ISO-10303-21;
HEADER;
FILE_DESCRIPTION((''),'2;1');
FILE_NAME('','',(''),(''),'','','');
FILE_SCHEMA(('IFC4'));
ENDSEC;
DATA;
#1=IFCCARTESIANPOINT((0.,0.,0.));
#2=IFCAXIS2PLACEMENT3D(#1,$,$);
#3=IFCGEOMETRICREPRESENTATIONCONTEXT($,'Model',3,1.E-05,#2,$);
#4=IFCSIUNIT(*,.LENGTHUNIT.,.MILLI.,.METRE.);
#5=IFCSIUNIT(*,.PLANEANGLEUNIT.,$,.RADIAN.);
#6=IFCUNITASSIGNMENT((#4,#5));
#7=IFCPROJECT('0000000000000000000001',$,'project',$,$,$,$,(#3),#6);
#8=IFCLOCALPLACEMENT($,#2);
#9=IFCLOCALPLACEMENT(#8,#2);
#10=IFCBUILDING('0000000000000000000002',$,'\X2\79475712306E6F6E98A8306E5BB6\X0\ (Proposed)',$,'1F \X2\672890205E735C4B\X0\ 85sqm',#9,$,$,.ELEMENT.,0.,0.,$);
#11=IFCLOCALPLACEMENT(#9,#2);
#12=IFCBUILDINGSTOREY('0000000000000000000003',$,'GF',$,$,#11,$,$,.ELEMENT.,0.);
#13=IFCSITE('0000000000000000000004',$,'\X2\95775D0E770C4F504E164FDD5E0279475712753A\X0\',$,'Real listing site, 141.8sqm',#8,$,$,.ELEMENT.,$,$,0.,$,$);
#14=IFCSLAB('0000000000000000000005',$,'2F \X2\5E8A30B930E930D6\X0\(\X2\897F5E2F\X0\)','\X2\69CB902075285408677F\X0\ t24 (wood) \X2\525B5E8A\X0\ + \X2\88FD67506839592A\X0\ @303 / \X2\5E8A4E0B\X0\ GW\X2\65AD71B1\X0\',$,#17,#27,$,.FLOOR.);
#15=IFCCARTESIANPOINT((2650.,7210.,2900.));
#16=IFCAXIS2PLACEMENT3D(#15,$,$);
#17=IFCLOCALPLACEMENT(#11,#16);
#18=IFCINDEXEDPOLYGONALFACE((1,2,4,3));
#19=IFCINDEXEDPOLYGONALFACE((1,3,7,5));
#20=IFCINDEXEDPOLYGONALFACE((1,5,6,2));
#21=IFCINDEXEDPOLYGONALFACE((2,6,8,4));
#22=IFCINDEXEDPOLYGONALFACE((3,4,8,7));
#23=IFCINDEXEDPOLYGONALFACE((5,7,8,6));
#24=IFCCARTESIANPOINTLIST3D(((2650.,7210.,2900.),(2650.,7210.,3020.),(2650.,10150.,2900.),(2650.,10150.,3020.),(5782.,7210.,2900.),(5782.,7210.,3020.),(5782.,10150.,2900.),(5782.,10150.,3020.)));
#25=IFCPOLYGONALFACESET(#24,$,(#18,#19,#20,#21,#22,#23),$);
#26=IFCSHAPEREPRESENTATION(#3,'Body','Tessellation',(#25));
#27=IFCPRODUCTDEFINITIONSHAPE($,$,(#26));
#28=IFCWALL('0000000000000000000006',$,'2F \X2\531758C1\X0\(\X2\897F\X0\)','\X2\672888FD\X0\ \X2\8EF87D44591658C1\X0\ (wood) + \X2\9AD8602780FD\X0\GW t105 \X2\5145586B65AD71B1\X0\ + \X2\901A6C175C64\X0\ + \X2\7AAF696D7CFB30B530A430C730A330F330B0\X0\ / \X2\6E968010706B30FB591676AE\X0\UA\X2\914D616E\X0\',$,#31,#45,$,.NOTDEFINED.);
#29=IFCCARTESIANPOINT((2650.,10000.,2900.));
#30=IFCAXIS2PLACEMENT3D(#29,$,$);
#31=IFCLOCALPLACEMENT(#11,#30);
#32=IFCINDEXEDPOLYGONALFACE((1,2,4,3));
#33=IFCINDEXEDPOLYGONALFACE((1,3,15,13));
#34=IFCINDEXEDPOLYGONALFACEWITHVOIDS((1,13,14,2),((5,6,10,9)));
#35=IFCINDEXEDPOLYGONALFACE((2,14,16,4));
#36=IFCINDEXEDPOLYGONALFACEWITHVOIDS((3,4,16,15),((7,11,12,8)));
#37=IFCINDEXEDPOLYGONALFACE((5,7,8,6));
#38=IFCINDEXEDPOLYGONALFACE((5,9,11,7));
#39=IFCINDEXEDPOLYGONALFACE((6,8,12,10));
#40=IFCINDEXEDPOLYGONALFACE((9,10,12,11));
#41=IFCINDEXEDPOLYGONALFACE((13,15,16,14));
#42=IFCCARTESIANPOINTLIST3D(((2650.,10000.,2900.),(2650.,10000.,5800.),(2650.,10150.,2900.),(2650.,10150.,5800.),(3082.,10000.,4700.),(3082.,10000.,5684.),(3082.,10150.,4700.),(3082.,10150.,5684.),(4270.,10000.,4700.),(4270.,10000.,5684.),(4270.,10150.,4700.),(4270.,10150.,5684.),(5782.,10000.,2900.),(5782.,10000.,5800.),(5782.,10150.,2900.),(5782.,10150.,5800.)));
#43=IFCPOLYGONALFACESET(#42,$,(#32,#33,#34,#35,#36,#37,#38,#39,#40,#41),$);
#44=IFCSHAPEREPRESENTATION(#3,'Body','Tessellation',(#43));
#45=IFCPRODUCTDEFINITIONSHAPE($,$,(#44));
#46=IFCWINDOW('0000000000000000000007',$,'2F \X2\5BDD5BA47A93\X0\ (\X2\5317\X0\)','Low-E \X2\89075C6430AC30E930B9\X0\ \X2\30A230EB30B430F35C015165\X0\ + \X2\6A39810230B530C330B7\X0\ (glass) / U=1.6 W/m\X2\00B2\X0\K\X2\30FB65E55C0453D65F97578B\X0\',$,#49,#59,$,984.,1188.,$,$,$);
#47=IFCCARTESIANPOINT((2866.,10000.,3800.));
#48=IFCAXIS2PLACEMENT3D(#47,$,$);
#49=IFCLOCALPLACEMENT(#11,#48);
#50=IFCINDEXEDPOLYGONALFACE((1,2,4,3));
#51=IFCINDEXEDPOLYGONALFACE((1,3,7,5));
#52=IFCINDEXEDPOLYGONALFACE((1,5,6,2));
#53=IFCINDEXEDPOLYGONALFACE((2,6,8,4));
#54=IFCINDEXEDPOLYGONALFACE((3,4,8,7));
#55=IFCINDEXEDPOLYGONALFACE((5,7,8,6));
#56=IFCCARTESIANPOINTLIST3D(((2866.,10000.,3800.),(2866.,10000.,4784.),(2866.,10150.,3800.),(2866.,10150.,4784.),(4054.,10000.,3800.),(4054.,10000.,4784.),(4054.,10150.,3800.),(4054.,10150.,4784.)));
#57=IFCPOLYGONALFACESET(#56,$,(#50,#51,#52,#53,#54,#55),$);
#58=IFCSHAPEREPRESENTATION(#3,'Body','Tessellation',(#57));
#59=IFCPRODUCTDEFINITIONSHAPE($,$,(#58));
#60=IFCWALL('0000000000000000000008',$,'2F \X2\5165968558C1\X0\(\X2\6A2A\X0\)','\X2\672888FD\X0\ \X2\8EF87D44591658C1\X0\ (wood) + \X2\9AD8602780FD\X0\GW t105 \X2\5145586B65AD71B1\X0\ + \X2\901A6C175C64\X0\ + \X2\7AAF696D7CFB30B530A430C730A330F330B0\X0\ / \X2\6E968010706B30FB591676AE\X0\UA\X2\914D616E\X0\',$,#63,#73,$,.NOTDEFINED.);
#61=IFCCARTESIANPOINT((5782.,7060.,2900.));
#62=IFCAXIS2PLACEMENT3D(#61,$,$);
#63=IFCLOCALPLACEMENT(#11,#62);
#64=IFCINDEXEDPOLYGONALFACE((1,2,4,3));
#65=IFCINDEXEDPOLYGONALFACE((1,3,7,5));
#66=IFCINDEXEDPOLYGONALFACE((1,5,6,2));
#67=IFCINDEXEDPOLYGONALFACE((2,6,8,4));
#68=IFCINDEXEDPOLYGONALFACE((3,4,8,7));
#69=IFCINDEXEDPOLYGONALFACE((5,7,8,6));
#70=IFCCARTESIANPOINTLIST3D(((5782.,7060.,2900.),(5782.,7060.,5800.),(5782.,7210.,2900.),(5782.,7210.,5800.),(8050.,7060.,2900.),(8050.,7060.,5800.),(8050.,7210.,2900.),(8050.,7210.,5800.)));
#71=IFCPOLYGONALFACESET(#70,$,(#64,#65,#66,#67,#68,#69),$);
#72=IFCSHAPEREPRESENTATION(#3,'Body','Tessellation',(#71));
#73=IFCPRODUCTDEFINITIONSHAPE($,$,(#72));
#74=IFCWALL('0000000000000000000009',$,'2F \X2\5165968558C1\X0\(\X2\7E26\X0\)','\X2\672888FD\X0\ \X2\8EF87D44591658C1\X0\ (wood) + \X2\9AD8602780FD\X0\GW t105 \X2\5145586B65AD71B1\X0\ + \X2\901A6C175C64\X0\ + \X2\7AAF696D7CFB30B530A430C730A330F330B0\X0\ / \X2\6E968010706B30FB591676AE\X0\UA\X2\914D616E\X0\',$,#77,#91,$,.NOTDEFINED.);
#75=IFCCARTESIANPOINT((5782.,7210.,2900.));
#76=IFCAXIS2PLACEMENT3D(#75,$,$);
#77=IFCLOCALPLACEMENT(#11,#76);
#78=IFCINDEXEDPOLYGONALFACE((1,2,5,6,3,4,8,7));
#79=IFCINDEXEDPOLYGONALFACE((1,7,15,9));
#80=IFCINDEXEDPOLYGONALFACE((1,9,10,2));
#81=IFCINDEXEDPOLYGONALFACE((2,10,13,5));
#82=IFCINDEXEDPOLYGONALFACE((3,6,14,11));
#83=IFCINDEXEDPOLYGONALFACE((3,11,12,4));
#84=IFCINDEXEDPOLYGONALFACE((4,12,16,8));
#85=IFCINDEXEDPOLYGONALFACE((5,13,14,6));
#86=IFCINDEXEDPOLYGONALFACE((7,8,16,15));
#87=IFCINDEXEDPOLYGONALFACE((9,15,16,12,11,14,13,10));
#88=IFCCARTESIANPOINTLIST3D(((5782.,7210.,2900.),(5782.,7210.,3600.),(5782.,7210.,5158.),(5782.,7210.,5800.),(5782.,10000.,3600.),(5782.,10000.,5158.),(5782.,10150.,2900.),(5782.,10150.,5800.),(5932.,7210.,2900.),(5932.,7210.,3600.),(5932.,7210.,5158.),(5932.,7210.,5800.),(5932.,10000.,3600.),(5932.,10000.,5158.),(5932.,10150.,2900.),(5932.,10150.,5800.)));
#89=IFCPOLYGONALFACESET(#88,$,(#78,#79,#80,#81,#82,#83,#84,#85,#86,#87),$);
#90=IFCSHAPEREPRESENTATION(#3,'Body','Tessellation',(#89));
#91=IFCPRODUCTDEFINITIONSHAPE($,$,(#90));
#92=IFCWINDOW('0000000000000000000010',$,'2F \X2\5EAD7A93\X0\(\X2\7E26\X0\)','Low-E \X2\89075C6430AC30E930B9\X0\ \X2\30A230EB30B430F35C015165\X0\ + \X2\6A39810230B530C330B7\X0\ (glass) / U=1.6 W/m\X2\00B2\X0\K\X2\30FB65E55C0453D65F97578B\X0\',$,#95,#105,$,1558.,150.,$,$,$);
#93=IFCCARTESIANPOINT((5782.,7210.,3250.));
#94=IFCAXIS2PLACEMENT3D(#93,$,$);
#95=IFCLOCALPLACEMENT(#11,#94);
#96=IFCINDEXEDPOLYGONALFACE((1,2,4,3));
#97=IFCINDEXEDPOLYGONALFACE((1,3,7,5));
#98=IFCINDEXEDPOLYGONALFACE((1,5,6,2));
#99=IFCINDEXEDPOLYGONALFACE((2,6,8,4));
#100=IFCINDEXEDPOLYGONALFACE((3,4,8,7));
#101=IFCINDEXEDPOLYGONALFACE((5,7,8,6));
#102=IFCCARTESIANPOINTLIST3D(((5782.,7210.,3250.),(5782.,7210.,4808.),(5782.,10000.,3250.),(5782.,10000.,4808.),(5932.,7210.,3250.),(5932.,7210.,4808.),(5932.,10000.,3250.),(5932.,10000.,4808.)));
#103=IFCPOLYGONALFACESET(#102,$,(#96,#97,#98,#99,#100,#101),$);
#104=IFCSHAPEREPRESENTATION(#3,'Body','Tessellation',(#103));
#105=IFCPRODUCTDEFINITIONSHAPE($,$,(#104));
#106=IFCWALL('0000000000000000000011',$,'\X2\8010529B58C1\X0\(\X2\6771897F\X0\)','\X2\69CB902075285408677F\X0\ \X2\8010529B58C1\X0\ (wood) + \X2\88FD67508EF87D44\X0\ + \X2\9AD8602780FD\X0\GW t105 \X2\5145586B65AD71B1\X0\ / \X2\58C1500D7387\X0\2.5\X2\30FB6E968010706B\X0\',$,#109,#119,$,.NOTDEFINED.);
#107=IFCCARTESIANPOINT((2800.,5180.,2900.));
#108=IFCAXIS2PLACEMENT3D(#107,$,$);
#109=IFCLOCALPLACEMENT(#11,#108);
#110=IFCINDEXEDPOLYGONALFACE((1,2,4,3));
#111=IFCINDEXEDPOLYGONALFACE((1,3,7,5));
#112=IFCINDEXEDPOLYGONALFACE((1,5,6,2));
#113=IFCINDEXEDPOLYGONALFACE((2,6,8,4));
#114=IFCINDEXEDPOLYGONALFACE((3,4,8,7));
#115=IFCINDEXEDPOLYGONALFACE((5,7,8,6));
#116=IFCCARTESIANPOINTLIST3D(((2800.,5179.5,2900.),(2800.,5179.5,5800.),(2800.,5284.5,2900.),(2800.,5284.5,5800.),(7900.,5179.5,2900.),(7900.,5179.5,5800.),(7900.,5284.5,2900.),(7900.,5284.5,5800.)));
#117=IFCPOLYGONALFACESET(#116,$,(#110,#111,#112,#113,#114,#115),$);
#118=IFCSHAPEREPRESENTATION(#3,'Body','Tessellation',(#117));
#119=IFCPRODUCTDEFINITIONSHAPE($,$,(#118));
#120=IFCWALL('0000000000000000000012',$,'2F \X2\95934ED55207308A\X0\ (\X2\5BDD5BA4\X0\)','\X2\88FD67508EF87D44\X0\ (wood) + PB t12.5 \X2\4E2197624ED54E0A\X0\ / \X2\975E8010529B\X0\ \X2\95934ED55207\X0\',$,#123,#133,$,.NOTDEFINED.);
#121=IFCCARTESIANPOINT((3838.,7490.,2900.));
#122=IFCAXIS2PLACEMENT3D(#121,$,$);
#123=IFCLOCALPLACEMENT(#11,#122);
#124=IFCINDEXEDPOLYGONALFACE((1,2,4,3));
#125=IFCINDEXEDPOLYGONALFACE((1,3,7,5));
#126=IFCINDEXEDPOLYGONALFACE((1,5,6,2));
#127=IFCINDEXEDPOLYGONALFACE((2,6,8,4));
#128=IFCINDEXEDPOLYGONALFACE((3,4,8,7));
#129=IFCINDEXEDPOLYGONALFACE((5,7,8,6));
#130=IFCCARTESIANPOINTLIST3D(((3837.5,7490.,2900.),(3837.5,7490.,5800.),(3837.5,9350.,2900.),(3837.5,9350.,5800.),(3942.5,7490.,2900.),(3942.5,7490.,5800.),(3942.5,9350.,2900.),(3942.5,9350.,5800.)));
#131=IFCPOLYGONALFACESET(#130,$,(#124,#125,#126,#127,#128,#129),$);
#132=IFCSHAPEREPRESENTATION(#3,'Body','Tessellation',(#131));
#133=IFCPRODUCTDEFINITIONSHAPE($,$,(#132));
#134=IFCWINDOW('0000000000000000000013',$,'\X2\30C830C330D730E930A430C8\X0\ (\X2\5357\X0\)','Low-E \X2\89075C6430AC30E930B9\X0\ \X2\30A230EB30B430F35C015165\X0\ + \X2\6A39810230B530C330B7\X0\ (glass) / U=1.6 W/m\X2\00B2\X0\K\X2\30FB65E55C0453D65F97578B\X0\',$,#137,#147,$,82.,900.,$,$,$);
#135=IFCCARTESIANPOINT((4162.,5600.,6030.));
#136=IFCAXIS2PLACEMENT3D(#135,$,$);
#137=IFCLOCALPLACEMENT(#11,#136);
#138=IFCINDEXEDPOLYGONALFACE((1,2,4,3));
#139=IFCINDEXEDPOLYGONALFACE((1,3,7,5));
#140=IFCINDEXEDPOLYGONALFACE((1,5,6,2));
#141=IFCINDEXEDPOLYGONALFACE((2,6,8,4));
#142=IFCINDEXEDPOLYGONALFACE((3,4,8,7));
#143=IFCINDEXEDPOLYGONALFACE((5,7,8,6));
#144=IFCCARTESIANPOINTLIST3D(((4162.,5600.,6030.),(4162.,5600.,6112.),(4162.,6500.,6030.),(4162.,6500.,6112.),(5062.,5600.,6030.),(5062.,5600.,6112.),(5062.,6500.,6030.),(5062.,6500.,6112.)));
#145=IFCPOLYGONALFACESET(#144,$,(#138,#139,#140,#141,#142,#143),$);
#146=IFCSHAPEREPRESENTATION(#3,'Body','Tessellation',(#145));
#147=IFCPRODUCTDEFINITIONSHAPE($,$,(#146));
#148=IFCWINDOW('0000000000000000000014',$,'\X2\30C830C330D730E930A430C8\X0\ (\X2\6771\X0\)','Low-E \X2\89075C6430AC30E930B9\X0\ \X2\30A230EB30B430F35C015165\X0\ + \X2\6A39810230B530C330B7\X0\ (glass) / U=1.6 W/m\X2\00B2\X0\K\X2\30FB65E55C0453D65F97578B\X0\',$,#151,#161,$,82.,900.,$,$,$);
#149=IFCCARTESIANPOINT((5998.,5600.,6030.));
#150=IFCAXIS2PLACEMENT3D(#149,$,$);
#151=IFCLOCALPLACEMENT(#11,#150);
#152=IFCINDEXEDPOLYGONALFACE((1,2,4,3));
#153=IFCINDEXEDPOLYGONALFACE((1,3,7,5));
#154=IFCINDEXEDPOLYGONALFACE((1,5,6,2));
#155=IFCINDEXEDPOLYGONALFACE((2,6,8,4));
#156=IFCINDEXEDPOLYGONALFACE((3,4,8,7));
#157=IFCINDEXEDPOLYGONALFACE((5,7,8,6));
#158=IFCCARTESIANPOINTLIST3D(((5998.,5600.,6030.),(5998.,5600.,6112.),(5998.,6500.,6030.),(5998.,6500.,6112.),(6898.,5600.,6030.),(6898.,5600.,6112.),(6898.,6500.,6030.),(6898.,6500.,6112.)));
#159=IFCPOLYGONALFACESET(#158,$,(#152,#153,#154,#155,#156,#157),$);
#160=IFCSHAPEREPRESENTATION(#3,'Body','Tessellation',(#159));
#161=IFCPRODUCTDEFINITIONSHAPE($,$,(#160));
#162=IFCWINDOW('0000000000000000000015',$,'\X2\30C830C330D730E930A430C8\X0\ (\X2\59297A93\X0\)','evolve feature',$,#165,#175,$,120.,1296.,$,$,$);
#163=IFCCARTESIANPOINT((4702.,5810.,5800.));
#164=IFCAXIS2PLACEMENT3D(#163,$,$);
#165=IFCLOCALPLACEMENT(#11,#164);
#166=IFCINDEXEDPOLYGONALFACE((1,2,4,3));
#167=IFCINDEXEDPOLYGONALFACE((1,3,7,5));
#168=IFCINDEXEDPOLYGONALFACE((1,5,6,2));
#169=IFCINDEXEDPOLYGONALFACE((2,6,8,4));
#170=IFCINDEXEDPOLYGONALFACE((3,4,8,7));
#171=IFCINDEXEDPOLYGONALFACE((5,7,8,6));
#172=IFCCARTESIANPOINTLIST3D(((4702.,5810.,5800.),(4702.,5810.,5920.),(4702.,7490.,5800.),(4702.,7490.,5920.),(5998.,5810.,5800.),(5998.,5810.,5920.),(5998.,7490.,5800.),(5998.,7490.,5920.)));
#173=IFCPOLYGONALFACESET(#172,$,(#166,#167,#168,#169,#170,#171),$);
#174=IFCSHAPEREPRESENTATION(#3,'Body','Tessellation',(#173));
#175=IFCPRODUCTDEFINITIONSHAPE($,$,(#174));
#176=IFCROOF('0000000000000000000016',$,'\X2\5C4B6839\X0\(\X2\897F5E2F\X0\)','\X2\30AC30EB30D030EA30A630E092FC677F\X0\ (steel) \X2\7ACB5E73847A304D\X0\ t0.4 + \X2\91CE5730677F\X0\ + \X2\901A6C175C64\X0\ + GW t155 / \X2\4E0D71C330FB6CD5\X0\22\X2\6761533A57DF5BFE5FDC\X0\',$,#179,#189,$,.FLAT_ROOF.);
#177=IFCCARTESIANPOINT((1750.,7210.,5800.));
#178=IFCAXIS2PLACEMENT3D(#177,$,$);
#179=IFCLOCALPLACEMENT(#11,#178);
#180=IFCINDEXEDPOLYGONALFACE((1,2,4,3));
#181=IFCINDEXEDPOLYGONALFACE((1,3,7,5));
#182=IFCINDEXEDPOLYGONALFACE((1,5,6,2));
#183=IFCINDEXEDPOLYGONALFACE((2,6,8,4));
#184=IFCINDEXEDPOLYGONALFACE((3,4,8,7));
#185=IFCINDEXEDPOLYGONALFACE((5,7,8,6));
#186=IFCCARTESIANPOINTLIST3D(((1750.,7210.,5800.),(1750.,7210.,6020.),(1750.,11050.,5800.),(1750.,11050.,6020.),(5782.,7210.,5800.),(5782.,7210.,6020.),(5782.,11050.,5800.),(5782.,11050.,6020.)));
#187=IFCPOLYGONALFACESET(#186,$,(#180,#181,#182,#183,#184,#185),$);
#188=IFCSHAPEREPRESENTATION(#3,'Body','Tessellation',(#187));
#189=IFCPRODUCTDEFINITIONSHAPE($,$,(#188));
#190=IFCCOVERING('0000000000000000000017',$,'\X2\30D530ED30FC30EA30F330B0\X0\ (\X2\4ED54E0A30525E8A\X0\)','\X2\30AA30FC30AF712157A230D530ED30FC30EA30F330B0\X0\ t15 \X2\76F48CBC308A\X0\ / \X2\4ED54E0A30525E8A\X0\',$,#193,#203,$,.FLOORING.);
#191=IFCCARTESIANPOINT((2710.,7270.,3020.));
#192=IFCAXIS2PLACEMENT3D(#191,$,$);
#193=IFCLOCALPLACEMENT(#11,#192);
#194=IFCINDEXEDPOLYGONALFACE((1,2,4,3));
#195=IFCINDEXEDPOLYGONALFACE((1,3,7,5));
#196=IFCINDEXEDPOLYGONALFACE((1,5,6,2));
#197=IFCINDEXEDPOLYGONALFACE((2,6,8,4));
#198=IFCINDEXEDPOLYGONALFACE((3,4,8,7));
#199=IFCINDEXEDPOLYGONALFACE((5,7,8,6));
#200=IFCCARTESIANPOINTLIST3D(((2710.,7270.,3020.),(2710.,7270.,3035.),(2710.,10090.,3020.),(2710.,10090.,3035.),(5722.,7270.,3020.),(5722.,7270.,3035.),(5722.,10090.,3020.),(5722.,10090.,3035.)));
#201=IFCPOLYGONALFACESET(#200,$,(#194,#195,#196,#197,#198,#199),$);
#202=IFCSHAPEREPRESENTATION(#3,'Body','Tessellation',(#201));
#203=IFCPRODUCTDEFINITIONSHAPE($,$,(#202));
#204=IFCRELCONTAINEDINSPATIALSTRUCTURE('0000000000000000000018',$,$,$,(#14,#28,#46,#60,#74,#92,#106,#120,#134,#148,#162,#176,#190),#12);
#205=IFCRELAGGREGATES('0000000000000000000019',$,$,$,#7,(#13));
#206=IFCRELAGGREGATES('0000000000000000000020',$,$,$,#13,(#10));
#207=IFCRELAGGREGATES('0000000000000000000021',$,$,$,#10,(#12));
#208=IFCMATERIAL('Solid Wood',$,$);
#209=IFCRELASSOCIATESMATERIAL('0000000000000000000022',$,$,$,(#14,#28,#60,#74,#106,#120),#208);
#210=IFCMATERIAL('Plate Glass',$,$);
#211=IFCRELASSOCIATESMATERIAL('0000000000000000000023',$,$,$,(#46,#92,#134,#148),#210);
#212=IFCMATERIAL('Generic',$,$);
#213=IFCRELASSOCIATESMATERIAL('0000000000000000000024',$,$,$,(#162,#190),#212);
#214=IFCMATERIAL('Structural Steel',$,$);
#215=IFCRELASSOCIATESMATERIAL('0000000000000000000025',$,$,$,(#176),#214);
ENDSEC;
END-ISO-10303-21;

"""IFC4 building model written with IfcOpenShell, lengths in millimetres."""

from ifc_helpers import new_model, si_unit, frame, frame_2d, origin, place, context, project, spatial, rectangle, extrude, material, element, fill, save


model = new_model("IFC4")

# Units and contexts
model_context = context("Model", 3, precision=1e-05, world=origin())
ifc_project = project(units=[si_unit("LENGTHUNIT", "METRE", prefix="MILLI"), si_unit("PLANEANGLEUNIT", "RADIAN")], contexts=[model_context])

# Site, building, storey
site_placement = place(None, origin())
site = spatial("IfcSite", under=ifc_project, at=site_placement, Name="長崎県佐世保市祇園町", ObjectType="Real listing site, 141.8sqm", CompositionType="ELEMENT", RefElevation=0.0)
building_placement = place(site_placement, origin())
building = spatial("IfcBuilding", under=site, at=building_placement, Name="祇園の潮風の家 (Proposed)", ObjectType="1F 木造平屋 85sqm", CompositionType="ELEMENT", ElevationOfRefHeight=0.0, ElevationOfTerrain=0.0)
storey_placement = place(building_placement, origin())
storey = spatial("IfcBuildingStorey", under=building, at=storey_placement, Name="GF", CompositionType="ELEMENT", Elevation=0.0)

# Slab
ifc_material_1 = material(Name="Solid Wood")
slab_placement = place(storey_placement, frame((2650.0, 7210.0, 2900.0)))
element("IfcSlab", 1, at=slab_placement, inside=storey, material=ifc_material_1, Name="2F 床スラブ(西帯)", Description="構造用合板 t24 (wood) 剛床 + 製材根太 @303 / 床下 GW断熱", PredefinedType="FLOOR", context=model_context, shape_type="SweptSolid", body=[
    extrude(rectangle(XDim=3132.0, YDim=2940.0, at=frame_2d((1566.0, 1470.0))), frame((2650.0, 7210.0, 2900.0)), (0.0, 0.0, 1.0), 120.0),
])

# Wall, opening, window
wall_1_placement = place(storey_placement, frame((2650.0, 10000.0, 2900.0)))
wall_1 = element("IfcWall", 2, at=wall_1_placement, inside=storey, material=ifc_material_1, Name="2F 北壁(西)", Description="木製 軸組外壁 (wood) + 高性能GW t105 充填断熱 + 通気層 + 窯業系サイディング / 準耐火・外皮UA配慮", PredefinedType="NOTDEFINED", context=model_context, shape_type="SweptSolid", body=[
    extrude(rectangle(XDim=3132.0, YDim=150.0, at=frame_2d((1566.0, 75.0))), frame((2650.0, 10000.0, 2900.0)), (0.0, 0.0, 1.0), 2900.0),
])
opening_1_placement = place(storey_placement, frame((2866.0, 10000.0, 3800.0)))
opening_1 = element("IfcOpeningElement", 3, at=opening_1_placement, cuts=wall_1, PredefinedType="NOTDEFINED", context=model_context, shape_type="SweptSolid", body=[
    extrude(rectangle(XDim=1188.0, YDim=150.0, at=frame_2d((594.0, 75.0))), frame((2866.0, 10000.0, 3800.0)), (0.0, 0.0, 1.0), 984.0),
])
ifc_material_2 = material(Name="Plate Glass")
window_1_placement = place(storey_placement, frame((2866.0, 10000.0, 3800.0)))
window_1 = element("IfcWindow", 4, at=window_1_placement, inside=storey, material=ifc_material_2, Name="2F 寝室窓 (北)", Description="Low-E 複層ガラス アルゴン封入 + 樹脂サッシ (glass) / U=1.6 W/m²K・日射取得型", OverallHeight=984.0, OverallWidth=1188.0, context=model_context, shape_type="SweptSolid", body=[
    extrude(rectangle(XDim=1188.0, YDim=150.0, at=frame_2d((594.0, 75.0))), frame((2866.0, 10000.0, 3800.0)), (0.0, 0.0, 1.0), 984.0),
])
fill(opening_1, window_1)

# Wall
wall_2_placement = place(storey_placement, frame((5782.0, 7060.0, 2900.0)))
element("IfcWall", 5, at=wall_2_placement, inside=storey, material=ifc_material_1, Name="2F 入隅壁(横)", Description="木製 軸組外壁 (wood) + 高性能GW t105 充填断熱 + 通気層 + 窯業系サイディング / 準耐火・外皮UA配慮", PredefinedType="NOTDEFINED", context=model_context, shape_type="SweptSolid", body=[
    extrude(rectangle(XDim=2268.0, YDim=150.0, at=frame_2d((1134.0, 75.0))), frame((5782.0, 7060.0, 2900.0)), (0.0, 0.0, 1.0), 2900.0),
])

# Wall, opening, window
wall_3_placement = place(storey_placement, frame((5782.0, 7210.0, 2900.0)))
wall_3 = element("IfcWall", 6, at=wall_3_placement, inside=storey, material=ifc_material_1, Name="2F 入隅壁(縦)", Description="木製 軸組外壁 (wood) + 高性能GW t105 充填断熱 + 通気層 + 窯業系サイディング / 準耐火・外皮UA配慮", PredefinedType="NOTDEFINED", context=model_context, shape_type="SweptSolid", body=[
    extrude(rectangle(XDim=150.0, YDim=2940.0, at=frame_2d((75.0, 1470.0))), frame((5782.0, 7210.0, 2900.0)), (0.0, 0.0, 1.0), 2900.0),
])
opening_2_placement = place(storey_placement, frame((5782.0, 7210.0, 3250.0)))
opening_2 = element("IfcOpeningElement", 7, at=opening_2_placement, cuts=wall_3, PredefinedType="NOTDEFINED", context=model_context, shape_type="SweptSolid", body=[
    extrude(rectangle(XDim=150.0, YDim=2790.0, at=frame_2d((75.0, 1395.0))), frame((5782.0, 7210.0, 3250.0)), (0.0, 0.0, 1.0), 1558.0),
])
window_2_placement = place(storey_placement, frame((5782.0, 7210.0, 3250.0)))
window_2 = element("IfcWindow", 8, at=window_2_placement, inside=storey, material=ifc_material_2, Name="2F 庭窓(縦)", Description="Low-E 複層ガラス アルゴン封入 + 樹脂サッシ (glass) / U=1.6 W/m²K・日射取得型", OverallHeight=1558.0, OverallWidth=150.0, context=model_context, shape_type="SweptSolid", body=[
    extrude(rectangle(XDim=150.0, YDim=2790.0, at=frame_2d((75.0, 1395.0))), frame((5782.0, 7210.0, 3250.0)), (0.0, 0.0, 1.0), 1558.0),
])
fill(opening_2, window_2)

# Walls
wall_4_placement = place(storey_placement, frame((2800.0, 5180.0, 2900.0)))
element("IfcWall", 9, at=wall_4_placement, inside=storey, material=ifc_material_1, Name="耐力壁(東西)", Description="構造用合板 耐力壁 (wood) + 製材軸組 + 高性能GW t105 充填断熱 / 壁倍率2.5・準耐火", PredefinedType="NOTDEFINED", context=model_context, shape_type="SweptSolid", body=[
    extrude(rectangle(XDim=5100.0, YDim=105.0, at=frame_2d((2550.0, 52.0))), frame((2800.0, 5180.0, 2900.0)), (0.0, 0.0, 1.0), 2900.0),
])
wall_5_placement = place(storey_placement, frame((3838.0, 7490.0, 2900.0)))
element("IfcWall", 10, at=wall_5_placement, inside=storey, material=ifc_material_1, Name="2F 間仕切り (寝室)", Description="製材軸組 (wood) + PB t12.5 両面仕上 / 非耐力 間仕切", PredefinedType="NOTDEFINED", context=model_context, shape_type="SweptSolid", body=[
    extrude(rectangle(XDim=105.0, YDim=1860.0, at=frame_2d((52.0, 930.0))), frame((3838.0, 7490.0, 2900.0)), (0.0, 0.0, 1.0), 2900.0),
])

# Windows
window_3_placement = place(storey_placement, frame((4162.0, 5600.0, 6030.0)))
element("IfcWindow", 11, at=window_3_placement, inside=storey, material=ifc_material_2, Name="トップライト (南)", Description="Low-E 複層ガラス アルゴン封入 + 樹脂サッシ (glass) / U=1.6 W/m²K・日射取得型", OverallHeight=82.0, OverallWidth=900.0, context=model_context, shape_type="SweptSolid", body=[
    extrude(rectangle(XDim=900.0, YDim=900.0, at=frame_2d((450.0, 450.0))), frame((4162.0, 5600.0, 6030.0)), (0.0, 0.0, 1.0), 82.0),
])
window_4_placement = place(storey_placement, frame((5998.0, 5600.0, 6030.0)))
element("IfcWindow", 12, at=window_4_placement, inside=storey, material=ifc_material_2, Name="トップライト (東)", Description="Low-E 複層ガラス アルゴン封入 + 樹脂サッシ (glass) / U=1.6 W/m²K・日射取得型", OverallHeight=82.0, OverallWidth=900.0, context=model_context, shape_type="SweptSolid", body=[
    extrude(rectangle(XDim=900.0, YDim=900.0, at=frame_2d((450.0, 450.0))), frame((5998.0, 5600.0, 6030.0)), (0.0, 0.0, 1.0), 82.0),
])
ifc_material_3 = material(Name="Generic")
window_5_placement = place(storey_placement, frame((4702.0, 5810.0, 5800.0)))
element("IfcWindow", 13, at=window_5_placement, inside=storey, material=ifc_material_3, Name="トップライト (天窓)", Description="evolve feature", OverallHeight=120.0, OverallWidth=1296.0, context=model_context, shape_type="SweptSolid", body=[
    extrude(rectangle(XDim=1296.0, YDim=1680.0, at=frame_2d((648.0, 840.0))), frame((4702.0, 5810.0, 5800.0)), (0.0, 0.0, 1.0), 120.0),
])

# Roof
ifc_material_4 = material(Name="Structural Steel")
for number, where, name in (
    (14, (1750.0, 7210.0, 5800.0), "屋根(西帯)"),
):
    element("IfcRoof", number, at=place(storey_placement, frame(where)), inside=storey, material=ifc_material_4, Name=name, Description="ガルバリウム鋼板 (steel) 立平葺き t0.4 + 野地板 + 通気層 + GW t155 / 不燃・法22条区域対応", PredefinedType="FLAT_ROOF", context=model_context, shape_type="SweptSolid", body=[
        extrude(rectangle(XDim=4032.0, YDim=3840.0, at=frame_2d((2016.0, 1920.0))), frame((1750.0, 7210.0, 5800.0)), (0.0, 0.0, 1.0), 220.0),
    ])

# Covering
covering_placement = place(storey_placement, frame((2710.0, 7270.0, 3020.0)))
element("IfcCovering", 15, at=covering_placement, inside=storey, material=ifc_material_3, Name="フローリング (仕上げ床)", Description="オーク無垢フローリング t15 直貼り / 仕上げ床", PredefinedType="FLOORING", context=model_context, shape_type="SweptSolid", body=[
    extrude(rectangle(XDim=3012.0, YDim=2820.0, at=frame_2d((1506.0, 1410.0))), frame((2710.0, 7270.0, 3020.0)), (0.0, 0.0, 1.0), 15.0),
])

save(model, "model.ifc")
